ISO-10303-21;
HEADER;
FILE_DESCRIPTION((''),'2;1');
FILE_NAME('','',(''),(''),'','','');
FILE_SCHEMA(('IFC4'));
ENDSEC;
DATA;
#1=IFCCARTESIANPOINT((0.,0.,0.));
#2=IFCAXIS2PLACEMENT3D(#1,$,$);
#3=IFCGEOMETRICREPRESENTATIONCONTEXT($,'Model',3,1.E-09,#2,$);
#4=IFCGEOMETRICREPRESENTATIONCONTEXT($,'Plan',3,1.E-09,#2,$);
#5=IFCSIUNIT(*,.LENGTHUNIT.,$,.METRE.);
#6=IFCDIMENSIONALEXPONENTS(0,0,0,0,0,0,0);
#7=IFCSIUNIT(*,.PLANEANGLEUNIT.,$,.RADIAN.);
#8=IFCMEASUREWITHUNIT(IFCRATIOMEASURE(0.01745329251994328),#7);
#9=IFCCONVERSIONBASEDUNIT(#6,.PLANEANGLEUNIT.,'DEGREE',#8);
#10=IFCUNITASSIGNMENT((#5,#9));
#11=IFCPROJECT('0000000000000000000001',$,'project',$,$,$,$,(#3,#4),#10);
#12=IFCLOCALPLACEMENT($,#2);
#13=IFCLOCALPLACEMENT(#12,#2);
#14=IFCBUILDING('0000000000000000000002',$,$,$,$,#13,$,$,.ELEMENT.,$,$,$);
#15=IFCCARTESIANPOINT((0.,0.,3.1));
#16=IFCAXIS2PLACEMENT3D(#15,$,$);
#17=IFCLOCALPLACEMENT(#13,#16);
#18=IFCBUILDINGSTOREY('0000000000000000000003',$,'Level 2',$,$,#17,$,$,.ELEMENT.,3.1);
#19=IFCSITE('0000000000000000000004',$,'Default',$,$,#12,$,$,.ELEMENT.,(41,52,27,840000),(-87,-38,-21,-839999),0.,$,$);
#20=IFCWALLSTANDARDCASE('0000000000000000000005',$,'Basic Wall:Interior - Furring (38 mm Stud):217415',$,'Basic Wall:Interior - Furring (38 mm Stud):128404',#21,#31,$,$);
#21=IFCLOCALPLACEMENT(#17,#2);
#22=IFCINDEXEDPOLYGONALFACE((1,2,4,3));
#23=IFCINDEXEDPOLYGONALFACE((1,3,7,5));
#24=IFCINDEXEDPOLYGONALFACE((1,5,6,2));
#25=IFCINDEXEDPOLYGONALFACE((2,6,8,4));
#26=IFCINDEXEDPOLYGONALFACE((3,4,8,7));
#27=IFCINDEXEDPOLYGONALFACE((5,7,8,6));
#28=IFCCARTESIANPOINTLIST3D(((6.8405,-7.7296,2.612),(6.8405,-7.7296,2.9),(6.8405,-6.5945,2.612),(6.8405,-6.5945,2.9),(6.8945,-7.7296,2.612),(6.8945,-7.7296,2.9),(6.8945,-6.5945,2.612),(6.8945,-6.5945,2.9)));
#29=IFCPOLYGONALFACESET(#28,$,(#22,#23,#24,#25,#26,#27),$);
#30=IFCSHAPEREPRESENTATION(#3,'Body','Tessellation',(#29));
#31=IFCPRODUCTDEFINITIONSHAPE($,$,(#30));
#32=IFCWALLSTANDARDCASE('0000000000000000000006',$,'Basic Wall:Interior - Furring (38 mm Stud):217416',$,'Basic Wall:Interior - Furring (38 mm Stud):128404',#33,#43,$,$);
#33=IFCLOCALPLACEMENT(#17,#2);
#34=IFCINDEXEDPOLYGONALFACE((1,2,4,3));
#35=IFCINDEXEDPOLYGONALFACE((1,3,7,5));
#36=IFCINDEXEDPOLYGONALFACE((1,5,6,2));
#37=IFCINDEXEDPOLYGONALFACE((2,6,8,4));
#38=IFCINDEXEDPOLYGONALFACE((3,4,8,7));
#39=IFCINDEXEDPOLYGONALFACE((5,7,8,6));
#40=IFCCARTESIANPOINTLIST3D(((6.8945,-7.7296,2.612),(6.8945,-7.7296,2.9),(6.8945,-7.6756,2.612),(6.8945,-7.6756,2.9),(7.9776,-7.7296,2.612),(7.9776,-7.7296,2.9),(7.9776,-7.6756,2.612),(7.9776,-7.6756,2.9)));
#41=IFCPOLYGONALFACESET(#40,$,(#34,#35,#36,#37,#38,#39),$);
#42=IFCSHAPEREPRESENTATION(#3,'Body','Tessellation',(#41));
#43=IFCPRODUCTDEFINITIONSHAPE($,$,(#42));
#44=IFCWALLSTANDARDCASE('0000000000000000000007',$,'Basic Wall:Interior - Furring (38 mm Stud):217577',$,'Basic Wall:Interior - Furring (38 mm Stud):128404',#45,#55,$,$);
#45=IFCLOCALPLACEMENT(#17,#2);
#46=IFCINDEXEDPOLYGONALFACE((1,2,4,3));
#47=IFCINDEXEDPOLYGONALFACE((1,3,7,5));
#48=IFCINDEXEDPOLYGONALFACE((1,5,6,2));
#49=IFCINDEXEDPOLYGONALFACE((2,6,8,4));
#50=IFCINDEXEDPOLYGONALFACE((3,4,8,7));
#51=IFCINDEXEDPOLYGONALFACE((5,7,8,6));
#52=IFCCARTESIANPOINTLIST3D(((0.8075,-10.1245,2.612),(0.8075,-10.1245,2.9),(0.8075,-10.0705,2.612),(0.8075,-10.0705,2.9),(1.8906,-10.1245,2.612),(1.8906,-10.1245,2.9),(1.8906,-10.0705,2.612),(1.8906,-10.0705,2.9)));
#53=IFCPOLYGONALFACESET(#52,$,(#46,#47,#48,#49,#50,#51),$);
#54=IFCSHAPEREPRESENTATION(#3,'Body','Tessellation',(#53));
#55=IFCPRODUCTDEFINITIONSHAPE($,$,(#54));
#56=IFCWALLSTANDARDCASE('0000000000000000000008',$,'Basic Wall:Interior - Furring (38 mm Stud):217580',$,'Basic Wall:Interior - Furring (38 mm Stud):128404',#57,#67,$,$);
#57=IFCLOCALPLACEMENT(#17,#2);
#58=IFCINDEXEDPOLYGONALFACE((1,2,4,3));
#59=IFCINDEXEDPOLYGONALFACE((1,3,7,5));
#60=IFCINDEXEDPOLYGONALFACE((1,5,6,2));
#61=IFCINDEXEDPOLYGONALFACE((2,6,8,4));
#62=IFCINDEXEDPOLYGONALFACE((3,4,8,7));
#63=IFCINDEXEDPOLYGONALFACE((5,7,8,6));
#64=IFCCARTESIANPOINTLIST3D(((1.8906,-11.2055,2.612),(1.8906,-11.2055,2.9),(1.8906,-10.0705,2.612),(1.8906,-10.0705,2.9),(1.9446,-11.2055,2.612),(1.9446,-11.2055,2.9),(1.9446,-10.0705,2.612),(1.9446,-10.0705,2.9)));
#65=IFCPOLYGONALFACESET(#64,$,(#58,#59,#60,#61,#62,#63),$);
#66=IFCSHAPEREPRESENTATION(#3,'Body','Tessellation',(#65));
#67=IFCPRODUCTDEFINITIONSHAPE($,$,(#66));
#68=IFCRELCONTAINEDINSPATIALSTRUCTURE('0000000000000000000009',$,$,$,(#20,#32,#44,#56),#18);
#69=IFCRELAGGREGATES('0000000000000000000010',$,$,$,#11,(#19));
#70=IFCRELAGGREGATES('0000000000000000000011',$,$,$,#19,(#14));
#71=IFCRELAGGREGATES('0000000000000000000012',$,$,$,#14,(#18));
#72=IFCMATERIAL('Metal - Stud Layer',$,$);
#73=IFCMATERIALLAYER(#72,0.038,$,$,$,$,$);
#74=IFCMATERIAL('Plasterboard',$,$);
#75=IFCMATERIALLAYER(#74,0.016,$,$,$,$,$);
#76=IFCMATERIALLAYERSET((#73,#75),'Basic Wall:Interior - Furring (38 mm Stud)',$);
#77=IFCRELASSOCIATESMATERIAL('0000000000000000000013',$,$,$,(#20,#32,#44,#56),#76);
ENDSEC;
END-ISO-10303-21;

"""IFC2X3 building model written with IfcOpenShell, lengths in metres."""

from ifc_helpers import new_model, entity, si_unit, converted_unit, frame, frame_2d, origin, place, context, project, spatial, rectangle, extrude, material, layer, layer_set, layer_usage, element, save


model = new_model("IFC2X3")

# Units and contexts
model_context = context("Model", 3, precision=1e-09, world=origin())
plan_context = context("Plan", 3, precision=1e-09, world=origin())
ifc_project = project(units=[si_unit("LENGTHUNIT", "METRE"), converted_unit("PLANEANGLEUNIT", "DEGREE", entity("IfcRatioMeasure", 0.01745329251994328), si_unit("PLANEANGLEUNIT", "RADIAN"), dimensions=[0, 0, 0, 0, 0, 0, 0])], contexts=[model_context, plan_context])

# Site, building, storey
site_placement = place(None, origin())
site = spatial("IfcSite", under=ifc_project, at=site_placement, Name="Default", CompositionType="ELEMENT", RefLatitude=(41, 52, 27, 840000), RefLongitude=(-87, -38, -21, -839999), RefElevation=0.0)
building_placement = place(site_placement, origin())
building = spatial("IfcBuilding", under=site, at=building_placement, CompositionType="ELEMENT")
storey_placement = place(building_placement, frame((0.0, 0.0, 3.1)))
storey = spatial("IfcBuildingStorey", under=building, at=storey_placement, Name="Level 2", CompositionType="ELEMENT", Elevation=3.1)

# Shared definitions
ifc_material_1 = material(Name="Plasterboard")
ifc_layer_1 = layer(ifc_material_1, 0.016)
ifc_material_2 = material(Name="Metal - Stud Layer")

# Walls
ifc_layer_2 = layer(ifc_material_2, 0.038)
ifc_layer_set_1 = layer_set([ifc_layer_2, ifc_layer_1], Name="Basic Wall:Interior - Furring (38 mm Stud)")
ifc_layer_usage_1 = layer_usage(ifc_layer_set_1, "AXIS2", "NEGATIVE", 0.027)
wall_1_placement = place(storey_placement, frame((6.8675, -7.7296, 2.612), z_axis=(0.0, 0.0, 1.0), x_axis=(0.0, 1.0, 0.0)))
element("IfcWallStandardCase", 1, at=wall_1_placement, inside=storey, material=ifc_layer_usage_1, Name="Basic Wall:Interior - Furring (38 mm Stud):217415", ObjectType="Basic Wall:Interior - Furring (38 mm Stud):128404", context=model_context, shape_type="SweptSolid", body=[
    extrude(rectangle(XDim=1.1351, YDim=0.054, at=frame_2d((0.5675, 0.0), x_axis=(-1.0, 0.0))), origin(), (0.0, 0.0, 1.0), 0.288),
])
wall_2_placement = place(storey_placement, frame((7.9776, -7.7026, 2.612), z_axis=(0.0, 0.0, 1.0), x_axis=(-1.0, 0.0, 0.0)))
element("IfcWallStandardCase", 2, at=wall_2_placement, inside=storey, material=ifc_layer_usage_1, Name="Basic Wall:Interior - Furring (38 mm Stud):217416", ObjectType="Basic Wall:Interior - Furring (38 mm Stud):128404", context=model_context, shape_type="SweptSolid", body=[
    extrude(rectangle(XDim=1.0831, YDim=0.054, at=frame_2d((0.5416, 0.0), x_axis=(-1.0, 0.0))), origin(), (0.0, 0.0, 1.0), 0.288),
])
wall_3_placement = place(storey_placement, frame((0.8075, -10.0975, 2.612)))
element("IfcWallStandardCase", 3, at=wall_3_placement, inside=storey, material=ifc_layer_usage_1, Name="Basic Wall:Interior - Furring (38 mm Stud):217577", ObjectType="Basic Wall:Interior - Furring (38 mm Stud):128404", context=model_context, shape_type="SweptSolid", body=[
    extrude(rectangle(XDim=1.0831, YDim=0.054, at=frame_2d((0.5415, 0.0), x_axis=(-1.0, 0.0))), origin(), (0.0, 0.0, 1.0), 0.288),
])
wall_4_placement = place(storey_placement, frame((1.9176, -10.0705, 2.612), z_axis=(0.0, 0.0, 1.0), x_axis=(0.0, -1.0, 0.0)))
element("IfcWallStandardCase", 4, at=wall_4_placement, inside=storey, material=ifc_layer_usage_1, Name="Basic Wall:Interior - Furring (38 mm Stud):217580", ObjectType="Basic Wall:Interior - Furring (38 mm Stud):128404", context=model_context, shape_type="SweptSolid", body=[
    extrude(rectangle(XDim=1.1351, YDim=0.054, at=frame_2d((0.5675, 0.0), x_axis=(-1.0, 0.0))), origin(), (0.0, 0.0, 1.0), 0.288),
])

save(model, "model.ifc")
